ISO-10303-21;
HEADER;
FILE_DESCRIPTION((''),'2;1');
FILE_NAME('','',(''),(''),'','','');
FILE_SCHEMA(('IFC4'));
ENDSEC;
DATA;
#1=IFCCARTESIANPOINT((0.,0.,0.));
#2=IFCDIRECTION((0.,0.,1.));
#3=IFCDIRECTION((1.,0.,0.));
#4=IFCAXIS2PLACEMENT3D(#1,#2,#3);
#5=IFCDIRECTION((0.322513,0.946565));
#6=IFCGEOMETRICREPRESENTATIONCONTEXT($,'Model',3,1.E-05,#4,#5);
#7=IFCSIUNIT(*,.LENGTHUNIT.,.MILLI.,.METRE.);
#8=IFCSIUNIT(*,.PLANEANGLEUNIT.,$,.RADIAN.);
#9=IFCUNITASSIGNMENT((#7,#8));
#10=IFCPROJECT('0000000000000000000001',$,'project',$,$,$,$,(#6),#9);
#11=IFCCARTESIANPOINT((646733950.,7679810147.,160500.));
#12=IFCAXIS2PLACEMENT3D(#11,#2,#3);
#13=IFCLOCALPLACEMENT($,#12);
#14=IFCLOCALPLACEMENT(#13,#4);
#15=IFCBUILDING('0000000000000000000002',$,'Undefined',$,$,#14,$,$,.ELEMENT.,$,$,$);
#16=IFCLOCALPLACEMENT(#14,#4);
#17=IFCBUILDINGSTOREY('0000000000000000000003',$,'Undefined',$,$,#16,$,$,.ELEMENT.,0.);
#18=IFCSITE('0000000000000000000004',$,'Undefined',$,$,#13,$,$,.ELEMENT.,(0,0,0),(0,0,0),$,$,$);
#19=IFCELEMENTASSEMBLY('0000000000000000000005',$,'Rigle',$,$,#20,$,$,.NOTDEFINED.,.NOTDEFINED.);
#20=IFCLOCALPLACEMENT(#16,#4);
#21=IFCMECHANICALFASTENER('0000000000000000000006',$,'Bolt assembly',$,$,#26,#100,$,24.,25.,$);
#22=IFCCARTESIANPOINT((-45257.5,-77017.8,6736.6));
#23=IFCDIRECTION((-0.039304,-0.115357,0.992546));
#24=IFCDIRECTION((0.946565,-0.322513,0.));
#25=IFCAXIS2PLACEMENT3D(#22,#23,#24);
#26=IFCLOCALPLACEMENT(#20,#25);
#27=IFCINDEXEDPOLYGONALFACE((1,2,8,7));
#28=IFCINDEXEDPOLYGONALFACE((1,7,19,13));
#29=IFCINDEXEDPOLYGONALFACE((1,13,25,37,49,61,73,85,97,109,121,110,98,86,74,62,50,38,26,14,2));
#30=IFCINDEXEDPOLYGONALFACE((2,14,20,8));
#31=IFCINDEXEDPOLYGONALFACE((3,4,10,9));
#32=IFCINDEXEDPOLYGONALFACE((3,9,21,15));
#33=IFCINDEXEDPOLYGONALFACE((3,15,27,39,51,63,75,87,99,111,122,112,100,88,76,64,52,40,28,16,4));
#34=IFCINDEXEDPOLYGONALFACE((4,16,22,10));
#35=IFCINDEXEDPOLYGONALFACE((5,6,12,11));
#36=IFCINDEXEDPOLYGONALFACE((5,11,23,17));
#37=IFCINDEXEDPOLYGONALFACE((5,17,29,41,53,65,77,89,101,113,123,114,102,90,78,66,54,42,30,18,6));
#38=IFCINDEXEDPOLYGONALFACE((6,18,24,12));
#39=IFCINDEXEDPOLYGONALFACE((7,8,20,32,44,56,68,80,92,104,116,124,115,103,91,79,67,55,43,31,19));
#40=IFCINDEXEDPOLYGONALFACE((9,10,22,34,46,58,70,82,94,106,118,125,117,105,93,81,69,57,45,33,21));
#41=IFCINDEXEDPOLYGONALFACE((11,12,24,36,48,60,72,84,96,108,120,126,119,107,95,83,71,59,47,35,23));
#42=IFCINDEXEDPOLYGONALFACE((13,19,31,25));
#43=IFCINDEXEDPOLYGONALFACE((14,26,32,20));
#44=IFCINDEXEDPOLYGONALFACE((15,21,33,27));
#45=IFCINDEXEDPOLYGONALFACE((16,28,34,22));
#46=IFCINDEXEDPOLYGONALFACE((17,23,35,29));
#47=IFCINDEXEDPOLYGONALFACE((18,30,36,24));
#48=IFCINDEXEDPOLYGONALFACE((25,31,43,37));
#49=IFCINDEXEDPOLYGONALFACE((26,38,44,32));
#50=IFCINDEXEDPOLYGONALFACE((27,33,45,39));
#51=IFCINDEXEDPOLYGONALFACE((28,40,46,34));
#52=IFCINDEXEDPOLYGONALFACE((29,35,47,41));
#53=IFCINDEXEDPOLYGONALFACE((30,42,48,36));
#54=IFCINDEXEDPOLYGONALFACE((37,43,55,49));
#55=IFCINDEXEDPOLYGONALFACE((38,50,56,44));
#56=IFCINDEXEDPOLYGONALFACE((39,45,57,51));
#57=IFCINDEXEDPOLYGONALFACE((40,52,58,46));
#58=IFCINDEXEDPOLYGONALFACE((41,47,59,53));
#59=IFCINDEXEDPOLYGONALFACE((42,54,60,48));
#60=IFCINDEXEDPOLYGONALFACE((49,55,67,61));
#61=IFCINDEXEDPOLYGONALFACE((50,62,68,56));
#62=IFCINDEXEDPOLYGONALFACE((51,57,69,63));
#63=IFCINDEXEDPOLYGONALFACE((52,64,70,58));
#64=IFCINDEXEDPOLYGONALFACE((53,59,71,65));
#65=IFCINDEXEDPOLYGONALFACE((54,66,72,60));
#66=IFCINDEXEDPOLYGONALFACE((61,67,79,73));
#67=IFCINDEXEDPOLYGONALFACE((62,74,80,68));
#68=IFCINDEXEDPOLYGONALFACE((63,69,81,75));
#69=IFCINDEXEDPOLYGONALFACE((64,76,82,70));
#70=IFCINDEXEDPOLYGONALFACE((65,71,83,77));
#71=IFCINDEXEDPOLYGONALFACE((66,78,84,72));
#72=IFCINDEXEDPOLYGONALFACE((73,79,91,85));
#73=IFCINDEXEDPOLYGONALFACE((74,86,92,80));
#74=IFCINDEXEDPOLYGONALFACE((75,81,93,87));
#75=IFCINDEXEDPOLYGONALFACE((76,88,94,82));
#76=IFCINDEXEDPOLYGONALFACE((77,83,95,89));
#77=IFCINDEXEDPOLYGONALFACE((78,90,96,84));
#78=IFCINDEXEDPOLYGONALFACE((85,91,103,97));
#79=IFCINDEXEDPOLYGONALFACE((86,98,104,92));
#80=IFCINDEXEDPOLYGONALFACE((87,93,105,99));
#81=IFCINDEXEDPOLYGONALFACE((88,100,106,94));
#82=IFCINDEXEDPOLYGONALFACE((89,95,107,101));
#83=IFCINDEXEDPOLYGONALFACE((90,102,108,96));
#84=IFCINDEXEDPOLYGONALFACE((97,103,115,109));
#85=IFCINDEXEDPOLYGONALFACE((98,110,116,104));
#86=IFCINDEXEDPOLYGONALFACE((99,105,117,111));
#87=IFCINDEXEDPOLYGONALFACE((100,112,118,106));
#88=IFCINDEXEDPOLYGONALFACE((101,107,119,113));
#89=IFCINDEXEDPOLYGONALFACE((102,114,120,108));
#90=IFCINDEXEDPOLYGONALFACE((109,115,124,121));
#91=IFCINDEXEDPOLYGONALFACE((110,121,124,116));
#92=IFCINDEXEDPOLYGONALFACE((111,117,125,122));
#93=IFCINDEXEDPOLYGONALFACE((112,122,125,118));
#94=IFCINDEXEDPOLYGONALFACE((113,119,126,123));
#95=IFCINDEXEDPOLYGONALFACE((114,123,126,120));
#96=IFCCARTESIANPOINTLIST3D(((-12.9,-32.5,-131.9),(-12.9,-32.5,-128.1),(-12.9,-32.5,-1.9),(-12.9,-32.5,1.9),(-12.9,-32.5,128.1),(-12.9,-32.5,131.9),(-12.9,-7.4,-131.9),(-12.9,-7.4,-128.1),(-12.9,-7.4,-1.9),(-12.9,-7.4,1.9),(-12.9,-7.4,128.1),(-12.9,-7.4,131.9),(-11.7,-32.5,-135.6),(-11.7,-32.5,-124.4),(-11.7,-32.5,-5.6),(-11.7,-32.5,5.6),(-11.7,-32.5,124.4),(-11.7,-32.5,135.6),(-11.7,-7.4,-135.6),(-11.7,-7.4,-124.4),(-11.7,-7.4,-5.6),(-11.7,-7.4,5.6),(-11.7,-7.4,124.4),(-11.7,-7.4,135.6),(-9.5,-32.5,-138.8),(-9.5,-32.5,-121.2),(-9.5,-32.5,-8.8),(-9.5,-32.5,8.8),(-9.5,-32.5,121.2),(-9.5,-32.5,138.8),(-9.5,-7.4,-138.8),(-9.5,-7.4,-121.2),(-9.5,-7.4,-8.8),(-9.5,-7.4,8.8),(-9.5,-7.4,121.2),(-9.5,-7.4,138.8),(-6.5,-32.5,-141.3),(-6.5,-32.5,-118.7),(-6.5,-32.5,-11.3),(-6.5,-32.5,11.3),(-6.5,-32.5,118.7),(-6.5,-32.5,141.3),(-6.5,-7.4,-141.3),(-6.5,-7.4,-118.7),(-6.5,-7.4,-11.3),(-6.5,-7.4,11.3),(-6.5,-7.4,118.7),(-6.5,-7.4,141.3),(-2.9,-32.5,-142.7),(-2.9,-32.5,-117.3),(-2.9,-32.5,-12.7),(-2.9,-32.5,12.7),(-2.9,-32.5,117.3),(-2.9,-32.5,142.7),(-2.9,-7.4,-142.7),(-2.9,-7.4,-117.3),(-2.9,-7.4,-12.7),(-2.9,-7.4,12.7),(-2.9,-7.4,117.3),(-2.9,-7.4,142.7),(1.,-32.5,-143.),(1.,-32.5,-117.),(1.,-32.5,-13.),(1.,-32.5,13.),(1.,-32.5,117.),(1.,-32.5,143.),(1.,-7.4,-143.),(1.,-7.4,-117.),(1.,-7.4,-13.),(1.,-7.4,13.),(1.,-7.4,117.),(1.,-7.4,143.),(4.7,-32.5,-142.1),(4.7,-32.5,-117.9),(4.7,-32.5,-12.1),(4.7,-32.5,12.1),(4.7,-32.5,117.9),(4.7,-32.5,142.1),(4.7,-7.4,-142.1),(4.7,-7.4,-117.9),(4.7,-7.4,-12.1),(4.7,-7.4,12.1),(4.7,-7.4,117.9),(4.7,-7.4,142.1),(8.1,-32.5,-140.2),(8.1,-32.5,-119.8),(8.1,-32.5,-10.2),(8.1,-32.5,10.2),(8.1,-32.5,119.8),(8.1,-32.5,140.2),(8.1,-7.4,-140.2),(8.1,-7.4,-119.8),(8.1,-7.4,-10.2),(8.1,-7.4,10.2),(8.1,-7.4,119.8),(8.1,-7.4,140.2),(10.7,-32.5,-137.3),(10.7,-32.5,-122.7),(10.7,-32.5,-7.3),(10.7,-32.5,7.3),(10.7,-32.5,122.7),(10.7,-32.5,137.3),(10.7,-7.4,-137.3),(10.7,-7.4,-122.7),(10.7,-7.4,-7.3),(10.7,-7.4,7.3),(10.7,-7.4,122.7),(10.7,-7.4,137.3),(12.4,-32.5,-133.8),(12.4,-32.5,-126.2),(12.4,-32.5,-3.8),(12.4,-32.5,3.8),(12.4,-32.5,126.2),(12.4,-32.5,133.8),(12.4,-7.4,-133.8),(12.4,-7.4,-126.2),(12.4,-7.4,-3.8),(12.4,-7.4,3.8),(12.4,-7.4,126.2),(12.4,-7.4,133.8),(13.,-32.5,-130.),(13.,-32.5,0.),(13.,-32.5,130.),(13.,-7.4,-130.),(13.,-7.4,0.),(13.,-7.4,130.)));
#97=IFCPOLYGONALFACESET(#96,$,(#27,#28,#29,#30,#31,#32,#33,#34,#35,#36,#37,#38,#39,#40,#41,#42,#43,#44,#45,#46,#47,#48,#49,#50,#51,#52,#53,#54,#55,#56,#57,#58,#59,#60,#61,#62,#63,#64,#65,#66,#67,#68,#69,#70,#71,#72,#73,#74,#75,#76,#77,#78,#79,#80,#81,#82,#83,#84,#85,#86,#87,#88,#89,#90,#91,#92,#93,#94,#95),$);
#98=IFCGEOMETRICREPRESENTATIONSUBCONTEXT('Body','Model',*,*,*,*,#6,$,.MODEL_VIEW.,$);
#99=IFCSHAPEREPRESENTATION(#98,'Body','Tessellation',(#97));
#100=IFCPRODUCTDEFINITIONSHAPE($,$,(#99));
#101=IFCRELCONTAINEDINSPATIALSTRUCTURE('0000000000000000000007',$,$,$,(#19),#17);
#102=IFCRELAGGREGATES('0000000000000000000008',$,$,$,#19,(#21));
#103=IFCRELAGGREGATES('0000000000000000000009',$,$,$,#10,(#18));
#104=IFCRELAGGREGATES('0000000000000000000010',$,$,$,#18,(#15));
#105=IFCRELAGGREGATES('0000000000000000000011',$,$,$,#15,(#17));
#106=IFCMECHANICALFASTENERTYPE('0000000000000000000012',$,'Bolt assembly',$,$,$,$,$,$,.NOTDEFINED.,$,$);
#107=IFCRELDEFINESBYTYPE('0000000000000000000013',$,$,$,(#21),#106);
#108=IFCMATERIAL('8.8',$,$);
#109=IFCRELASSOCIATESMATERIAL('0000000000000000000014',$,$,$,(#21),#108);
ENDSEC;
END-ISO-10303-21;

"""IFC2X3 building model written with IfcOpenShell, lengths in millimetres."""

from ifc_helpers import new_model, si_unit, direction, frame, origin_with_axes, origin_2d_with_axis, place, context, subcontext, project, spatial, circle, extrude, source, transform, mapped, material, type_object, element, aggregate, save


model = new_model("IFC2X3")

# Units and contexts
model_context = context("Model", 3, precision=1e-05, world=origin_with_axes(), true_north=direction((0.322513, 0.946565)))
body_context = subcontext(model_context, "Body", "Model", "MODEL_VIEW")
ifc_project = project(units=[si_unit("LENGTHUNIT", "METRE", prefix="MILLI"), si_unit("PLANEANGLEUNIT", "RADIAN")], contexts=[model_context])

# Site, building, storey
site_placement = place(None, frame((646733950.0, 7679810147.0, 160500.0), z_axis=(0.0, 0.0, 1.0), x_axis=(1.0, 0.0, 0.0)))
site = spatial("IfcSite", under=ifc_project, at=site_placement, Name="Undefined", CompositionType="ELEMENT", RefLatitude=(0, 0, 0), RefLongitude=(0, 0, 0))
building_placement = place(site_placement, origin_with_axes())
building = spatial("IfcBuilding", under=site, at=building_placement, Name="Undefined", CompositionType="ELEMENT")
storey_placement = place(building_placement, origin_with_axes())
storey = spatial("IfcBuildingStorey", under=building, at=storey_placement, Name="Undefined", CompositionType="ELEMENT", Elevation=0.0)

# Element assembly
assembly_1_placement = place(storey_placement, origin_with_axes())
assembly_1 = element("IfcElementAssembly", 1, at=assembly_1_placement, inside=storey, Name="Rigle", AssemblyPlace="NOTDEFINED", PredefinedType="NOTDEFINED")

# Shared definitions
ifc_material_1 = material(Name="8.8")
mechanical_fastener_type = type_object("IfcMechanicalFastenerType", Name="Bolt assembly")

# Mechanical fastener
shared_shape_1 = source(origin_with_axes(), body_context, "Body", "SweptSolid", [
    extrude(circle(Radius=13.0, at=origin_2d_with_axis()), frame((0.0, -32.5, 0.0), z_axis=(0.0, 1.0, 0.0), x_axis=(1.0, 0.0, 0.0)), (0.0, 0.0, 1.0), 25.1),
])
mechanical_fastener_1_placement = place(assembly_1_placement, frame((-45257.5, -77017.8, 6736.6), z_axis=(-0.039304, -0.115357, 0.992546), x_axis=(0.946565, -0.322513, 0.0)))
mechanical_fastener_1 = element("IfcMechanicalFastener", 2, at=mechanical_fastener_1_placement, type_object=mechanical_fastener_type, material=ifc_material_1, Name="Bolt assembly", NominalDiameter=24.0, NominalLength=25.0, context=body_context, shape_type="MappedRepresentation", body=[
    mapped(shared_shape_1, transform((0.0, 0.0, -130.0))),
    mapped(shared_shape_1, transform((0.0, 0.0, 0.0))),
    mapped(shared_shape_1, transform((0.0, 0.0, 130.0))),
])
aggregate(assembly_1, [mechanical_fastener_1])

save(model, "model.ifc")
